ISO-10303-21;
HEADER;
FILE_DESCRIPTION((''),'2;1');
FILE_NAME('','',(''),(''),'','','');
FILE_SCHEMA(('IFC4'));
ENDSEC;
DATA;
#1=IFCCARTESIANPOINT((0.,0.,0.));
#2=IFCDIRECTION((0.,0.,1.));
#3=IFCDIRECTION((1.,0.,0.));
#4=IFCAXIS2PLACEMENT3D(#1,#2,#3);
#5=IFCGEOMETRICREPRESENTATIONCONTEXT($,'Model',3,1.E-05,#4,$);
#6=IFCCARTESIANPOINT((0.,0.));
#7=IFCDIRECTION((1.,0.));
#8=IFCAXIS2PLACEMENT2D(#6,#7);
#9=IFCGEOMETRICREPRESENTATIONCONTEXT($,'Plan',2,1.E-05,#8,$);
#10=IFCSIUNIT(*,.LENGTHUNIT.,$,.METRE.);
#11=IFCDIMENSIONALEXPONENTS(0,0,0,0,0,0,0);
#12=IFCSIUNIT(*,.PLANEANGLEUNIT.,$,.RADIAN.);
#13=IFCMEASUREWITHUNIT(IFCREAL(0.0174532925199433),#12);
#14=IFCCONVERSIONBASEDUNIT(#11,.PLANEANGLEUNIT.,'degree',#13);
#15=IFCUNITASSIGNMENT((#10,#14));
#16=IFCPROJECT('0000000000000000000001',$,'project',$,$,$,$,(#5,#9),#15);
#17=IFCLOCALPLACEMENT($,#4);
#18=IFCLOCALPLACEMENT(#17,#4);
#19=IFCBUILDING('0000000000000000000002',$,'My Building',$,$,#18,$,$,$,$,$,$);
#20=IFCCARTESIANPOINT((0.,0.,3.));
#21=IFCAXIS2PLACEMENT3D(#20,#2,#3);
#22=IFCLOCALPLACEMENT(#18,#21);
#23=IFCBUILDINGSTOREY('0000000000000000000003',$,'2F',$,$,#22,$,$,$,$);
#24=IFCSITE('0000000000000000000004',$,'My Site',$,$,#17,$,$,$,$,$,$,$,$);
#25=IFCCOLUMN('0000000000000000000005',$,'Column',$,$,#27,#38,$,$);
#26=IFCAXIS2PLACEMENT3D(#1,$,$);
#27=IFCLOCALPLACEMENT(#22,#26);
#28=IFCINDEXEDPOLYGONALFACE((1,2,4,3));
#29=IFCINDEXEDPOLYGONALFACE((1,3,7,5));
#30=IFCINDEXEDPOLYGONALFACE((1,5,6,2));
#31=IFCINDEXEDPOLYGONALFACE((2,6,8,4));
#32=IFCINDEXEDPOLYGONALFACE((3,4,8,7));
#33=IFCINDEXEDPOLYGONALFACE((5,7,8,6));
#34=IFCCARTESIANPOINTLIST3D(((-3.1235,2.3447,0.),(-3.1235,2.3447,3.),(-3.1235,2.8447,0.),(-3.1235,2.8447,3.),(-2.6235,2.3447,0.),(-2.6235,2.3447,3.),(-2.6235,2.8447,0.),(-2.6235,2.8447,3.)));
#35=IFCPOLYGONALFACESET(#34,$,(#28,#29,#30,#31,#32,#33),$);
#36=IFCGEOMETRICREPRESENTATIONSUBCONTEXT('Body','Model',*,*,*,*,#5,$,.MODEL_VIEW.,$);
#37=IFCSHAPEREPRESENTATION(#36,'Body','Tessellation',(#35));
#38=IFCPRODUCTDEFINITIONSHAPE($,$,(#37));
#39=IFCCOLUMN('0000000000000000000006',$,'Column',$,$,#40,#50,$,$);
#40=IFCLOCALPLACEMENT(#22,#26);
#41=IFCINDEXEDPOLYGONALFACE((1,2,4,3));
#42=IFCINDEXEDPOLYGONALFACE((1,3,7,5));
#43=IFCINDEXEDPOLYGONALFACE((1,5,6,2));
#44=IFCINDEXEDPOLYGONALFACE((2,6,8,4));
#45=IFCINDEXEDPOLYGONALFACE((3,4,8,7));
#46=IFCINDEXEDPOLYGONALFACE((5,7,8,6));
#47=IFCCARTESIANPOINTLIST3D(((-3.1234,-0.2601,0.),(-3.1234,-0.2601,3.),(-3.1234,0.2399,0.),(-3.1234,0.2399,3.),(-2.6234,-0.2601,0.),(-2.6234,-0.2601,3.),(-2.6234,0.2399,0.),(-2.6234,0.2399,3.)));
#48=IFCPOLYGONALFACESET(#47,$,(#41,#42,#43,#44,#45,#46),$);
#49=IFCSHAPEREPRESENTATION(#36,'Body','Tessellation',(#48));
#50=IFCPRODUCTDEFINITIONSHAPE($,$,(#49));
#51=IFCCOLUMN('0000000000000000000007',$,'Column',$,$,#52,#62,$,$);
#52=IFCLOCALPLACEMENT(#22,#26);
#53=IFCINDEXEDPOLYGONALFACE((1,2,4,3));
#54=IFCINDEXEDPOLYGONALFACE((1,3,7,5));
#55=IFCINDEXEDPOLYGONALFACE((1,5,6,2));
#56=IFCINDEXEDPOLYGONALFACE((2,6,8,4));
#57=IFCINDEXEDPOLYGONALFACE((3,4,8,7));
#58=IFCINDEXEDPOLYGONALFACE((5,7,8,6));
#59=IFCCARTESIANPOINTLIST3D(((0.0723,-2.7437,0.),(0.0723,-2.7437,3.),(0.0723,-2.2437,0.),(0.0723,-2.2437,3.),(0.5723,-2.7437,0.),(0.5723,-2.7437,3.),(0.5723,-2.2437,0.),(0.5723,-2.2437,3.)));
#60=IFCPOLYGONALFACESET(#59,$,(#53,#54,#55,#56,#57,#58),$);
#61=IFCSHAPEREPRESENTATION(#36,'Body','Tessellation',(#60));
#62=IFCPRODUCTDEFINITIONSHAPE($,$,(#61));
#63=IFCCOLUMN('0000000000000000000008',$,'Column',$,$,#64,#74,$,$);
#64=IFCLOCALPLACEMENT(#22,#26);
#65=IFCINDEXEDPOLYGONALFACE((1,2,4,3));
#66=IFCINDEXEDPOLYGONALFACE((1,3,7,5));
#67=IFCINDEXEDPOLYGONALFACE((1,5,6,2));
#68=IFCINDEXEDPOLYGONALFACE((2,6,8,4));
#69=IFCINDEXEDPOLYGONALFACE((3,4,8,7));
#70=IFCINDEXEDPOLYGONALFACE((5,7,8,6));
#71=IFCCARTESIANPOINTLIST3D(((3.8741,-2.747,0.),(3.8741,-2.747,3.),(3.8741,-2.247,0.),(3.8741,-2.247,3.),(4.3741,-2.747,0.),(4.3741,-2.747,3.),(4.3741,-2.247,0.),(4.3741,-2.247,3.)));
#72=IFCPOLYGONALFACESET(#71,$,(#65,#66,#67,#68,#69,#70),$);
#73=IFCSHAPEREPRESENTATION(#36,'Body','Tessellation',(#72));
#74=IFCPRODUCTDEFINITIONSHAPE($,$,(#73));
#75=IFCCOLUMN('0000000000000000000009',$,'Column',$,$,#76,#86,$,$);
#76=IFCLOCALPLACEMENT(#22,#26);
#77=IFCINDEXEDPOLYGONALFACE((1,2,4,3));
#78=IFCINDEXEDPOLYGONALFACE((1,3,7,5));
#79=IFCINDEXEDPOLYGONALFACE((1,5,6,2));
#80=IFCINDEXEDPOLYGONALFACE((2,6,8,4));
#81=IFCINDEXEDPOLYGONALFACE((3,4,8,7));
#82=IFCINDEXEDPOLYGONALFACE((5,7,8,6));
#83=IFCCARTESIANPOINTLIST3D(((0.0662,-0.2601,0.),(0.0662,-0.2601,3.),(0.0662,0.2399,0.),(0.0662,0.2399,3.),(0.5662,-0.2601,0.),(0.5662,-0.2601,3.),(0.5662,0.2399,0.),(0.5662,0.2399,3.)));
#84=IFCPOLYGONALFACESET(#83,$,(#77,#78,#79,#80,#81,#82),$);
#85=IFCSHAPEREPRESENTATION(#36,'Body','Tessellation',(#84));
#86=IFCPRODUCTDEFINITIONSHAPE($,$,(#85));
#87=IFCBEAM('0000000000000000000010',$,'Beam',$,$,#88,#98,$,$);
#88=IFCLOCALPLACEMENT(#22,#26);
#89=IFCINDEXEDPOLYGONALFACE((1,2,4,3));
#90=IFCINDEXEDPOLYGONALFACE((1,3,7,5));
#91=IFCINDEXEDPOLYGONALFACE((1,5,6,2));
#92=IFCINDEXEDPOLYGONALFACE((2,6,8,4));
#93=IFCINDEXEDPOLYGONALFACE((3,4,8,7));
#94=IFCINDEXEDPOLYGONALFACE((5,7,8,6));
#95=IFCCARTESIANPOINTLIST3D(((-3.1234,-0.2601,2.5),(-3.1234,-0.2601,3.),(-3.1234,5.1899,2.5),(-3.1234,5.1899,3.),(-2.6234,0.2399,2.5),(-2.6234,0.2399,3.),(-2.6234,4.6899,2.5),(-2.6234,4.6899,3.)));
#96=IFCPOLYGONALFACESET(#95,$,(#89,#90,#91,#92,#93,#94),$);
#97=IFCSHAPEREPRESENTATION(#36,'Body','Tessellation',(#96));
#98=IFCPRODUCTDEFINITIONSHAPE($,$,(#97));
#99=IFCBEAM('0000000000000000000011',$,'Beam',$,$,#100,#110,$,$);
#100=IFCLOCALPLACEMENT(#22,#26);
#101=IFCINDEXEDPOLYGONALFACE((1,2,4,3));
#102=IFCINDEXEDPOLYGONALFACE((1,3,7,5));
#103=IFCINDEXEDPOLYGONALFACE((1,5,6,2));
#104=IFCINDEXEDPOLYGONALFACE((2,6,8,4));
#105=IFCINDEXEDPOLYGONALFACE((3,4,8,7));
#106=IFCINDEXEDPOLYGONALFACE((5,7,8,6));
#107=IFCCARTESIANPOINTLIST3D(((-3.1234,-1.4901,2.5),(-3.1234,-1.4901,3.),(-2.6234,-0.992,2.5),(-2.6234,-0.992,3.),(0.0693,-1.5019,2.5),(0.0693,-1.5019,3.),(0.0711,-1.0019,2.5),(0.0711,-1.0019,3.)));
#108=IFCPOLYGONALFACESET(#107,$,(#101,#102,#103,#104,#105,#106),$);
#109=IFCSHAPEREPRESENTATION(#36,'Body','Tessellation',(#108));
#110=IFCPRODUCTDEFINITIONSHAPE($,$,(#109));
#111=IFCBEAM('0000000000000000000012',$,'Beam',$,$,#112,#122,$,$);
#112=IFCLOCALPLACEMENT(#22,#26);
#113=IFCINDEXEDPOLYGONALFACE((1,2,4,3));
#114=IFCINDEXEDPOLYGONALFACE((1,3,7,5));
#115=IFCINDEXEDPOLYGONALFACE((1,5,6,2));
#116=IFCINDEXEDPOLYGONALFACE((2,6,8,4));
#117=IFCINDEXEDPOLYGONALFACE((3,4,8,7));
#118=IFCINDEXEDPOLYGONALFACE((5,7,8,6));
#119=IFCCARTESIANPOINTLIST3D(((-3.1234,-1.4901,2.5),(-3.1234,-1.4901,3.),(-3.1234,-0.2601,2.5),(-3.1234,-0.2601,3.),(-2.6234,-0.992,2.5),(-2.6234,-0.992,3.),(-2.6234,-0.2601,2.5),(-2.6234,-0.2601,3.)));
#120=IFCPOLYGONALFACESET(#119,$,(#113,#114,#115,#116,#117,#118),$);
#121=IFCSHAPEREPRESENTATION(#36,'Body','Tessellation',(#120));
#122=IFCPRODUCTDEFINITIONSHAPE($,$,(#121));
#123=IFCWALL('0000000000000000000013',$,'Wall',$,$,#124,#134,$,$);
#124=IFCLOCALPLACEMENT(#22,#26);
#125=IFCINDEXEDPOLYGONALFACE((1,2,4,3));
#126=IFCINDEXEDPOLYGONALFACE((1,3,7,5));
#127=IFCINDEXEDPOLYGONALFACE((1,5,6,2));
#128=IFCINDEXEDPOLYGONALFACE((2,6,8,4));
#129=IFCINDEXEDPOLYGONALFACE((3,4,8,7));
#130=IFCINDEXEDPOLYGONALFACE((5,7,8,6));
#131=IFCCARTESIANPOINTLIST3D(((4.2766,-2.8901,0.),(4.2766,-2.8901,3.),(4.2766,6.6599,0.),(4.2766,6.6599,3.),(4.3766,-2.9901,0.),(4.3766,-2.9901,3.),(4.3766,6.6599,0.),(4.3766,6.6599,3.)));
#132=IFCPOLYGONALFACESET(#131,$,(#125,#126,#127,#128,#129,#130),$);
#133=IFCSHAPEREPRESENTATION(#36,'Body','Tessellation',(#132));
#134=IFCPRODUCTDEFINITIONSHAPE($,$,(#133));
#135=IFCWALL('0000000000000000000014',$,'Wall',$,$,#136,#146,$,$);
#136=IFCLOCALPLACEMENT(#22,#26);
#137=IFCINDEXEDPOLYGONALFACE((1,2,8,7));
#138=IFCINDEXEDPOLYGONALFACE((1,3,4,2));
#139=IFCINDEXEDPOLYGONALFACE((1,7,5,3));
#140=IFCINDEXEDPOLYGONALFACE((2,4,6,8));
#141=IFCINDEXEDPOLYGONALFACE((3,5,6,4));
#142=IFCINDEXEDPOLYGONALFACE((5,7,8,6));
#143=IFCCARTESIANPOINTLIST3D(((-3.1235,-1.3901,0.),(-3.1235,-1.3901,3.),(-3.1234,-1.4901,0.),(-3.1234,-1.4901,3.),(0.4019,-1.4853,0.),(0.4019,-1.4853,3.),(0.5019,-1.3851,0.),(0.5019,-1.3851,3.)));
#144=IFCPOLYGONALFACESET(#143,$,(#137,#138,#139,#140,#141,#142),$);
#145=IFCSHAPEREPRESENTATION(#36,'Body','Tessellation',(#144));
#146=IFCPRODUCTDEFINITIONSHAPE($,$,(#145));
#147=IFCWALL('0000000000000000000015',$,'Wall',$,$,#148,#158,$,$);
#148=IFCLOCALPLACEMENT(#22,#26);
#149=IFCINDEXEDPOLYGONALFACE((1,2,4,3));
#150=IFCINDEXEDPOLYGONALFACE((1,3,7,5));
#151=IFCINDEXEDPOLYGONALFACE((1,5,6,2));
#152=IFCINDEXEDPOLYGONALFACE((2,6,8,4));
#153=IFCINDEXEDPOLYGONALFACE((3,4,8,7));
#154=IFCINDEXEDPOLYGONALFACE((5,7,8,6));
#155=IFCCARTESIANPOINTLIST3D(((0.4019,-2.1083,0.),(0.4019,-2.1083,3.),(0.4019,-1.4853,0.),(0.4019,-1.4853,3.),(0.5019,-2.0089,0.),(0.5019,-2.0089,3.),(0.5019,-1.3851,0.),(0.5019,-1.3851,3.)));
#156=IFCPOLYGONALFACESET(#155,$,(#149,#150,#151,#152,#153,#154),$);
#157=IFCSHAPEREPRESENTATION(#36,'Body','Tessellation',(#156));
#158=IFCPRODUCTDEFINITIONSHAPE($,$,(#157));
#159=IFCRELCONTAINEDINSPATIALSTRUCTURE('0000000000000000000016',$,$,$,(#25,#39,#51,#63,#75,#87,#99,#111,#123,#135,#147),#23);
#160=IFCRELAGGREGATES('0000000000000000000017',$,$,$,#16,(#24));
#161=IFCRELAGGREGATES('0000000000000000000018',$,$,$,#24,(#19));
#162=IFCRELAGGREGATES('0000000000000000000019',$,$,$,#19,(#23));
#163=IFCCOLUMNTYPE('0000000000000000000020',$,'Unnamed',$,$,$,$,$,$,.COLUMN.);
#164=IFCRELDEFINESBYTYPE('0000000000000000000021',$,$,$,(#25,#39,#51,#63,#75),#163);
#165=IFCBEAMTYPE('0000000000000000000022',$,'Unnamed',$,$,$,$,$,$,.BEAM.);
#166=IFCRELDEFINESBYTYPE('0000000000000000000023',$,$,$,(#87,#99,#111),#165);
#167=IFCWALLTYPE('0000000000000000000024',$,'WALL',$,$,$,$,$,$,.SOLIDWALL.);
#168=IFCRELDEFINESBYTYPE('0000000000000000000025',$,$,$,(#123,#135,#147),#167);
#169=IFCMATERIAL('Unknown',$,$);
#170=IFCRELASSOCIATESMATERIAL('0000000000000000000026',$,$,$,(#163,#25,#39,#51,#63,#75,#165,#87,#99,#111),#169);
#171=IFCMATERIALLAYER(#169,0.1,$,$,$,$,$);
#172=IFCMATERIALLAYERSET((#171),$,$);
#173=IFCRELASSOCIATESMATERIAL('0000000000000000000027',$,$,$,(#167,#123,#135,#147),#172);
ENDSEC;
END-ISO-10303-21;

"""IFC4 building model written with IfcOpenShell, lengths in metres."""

from ifc_helpers import new_model, entity, si_unit, converted_unit, frame, origin_with_axes, origin_2d_with_axis, place, context, subcontext, project, spatial, line, indexed_curve, rectangle, outline, extrude, clip, halfspace, material, layer, layer_set, layer_usage, material_profile, profile_set, profile_usage, type_object, element, save


model = new_model("IFC4")

# Units and contexts
model_context = context("Model", 3, precision=1e-05, world=origin_with_axes())
plan_context = context("Plan", 2, precision=1e-05, world=origin_2d_with_axis())
body_context_1 = subcontext(model_context, "Body", "Model", "MODEL_VIEW")
ifc_project = project(units=[si_unit("LENGTHUNIT", "METRE"), converted_unit("PLANEANGLEUNIT", "degree", entity("IfcReal", 0.0174532925199433), si_unit("PLANEANGLEUNIT", "RADIAN"), dimensions=[0, 0, 0, 0, 0, 0, 0])], contexts=[model_context, plan_context])

# Site, building, storey
site_placement = place(None, origin_with_axes())
site = spatial("IfcSite", under=ifc_project, at=site_placement, Name="My Site")
building_placement = place(site_placement, origin_with_axes())
building = spatial("IfcBuilding", under=site, at=building_placement, Name="My Building")
storey_placement = place(building_placement, frame((0.0, 0.0, 3.0), z_axis=(0.0, 0.0, 1.0), x_axis=(1.0, 0.0, 0.0)))
storey = spatial("IfcBuildingStorey", under=building, at=storey_placement, Name="2F")

# Columns
ifc_material = material(Name="Unknown")
ifc_material_profile_1 = material_profile(ifc_material, rectangle(XDim=0.5, YDim=0.5))
ifc_profile_set_1 = profile_set([ifc_material_profile_1])
ifc_profile_usage_1 = profile_usage(ifc_profile_set_1, cardinal=1)
column_type = type_object("IfcColumnType", Name="Unnamed", PredefinedType="COLUMN", material=ifc_profile_set_1)
column_1_placement = place(storey_placement, frame((-2.6235, 2.3447, 0.0), z_axis=(0.0, 0.0, 1.0), x_axis=(1.0, 0.0, 0.0)))
element("IfcColumn", 1, at=column_1_placement, inside=storey, type_object=column_type, material=ifc_profile_usage_1, Name="Column", context=body_context_1, shape_type="SweptSolid", body=[
    extrude(rectangle(XDim=0.5, YDim=0.5), frame((-0.25, 0.25, 0.0), z_axis=(0.0, 0.0, 1.0), x_axis=(1.0, 0.0, 0.0)), (0.0, 0.0, 1.0), 3.0),
])
ifc_profile_usage_2 = profile_usage(ifc_profile_set_1, cardinal=1)
column_2_placement = place(storey_placement, frame((-2.6234, -0.2601, 0.0), z_axis=(0.0, 0.0, 1.0), x_axis=(1.0, 0.0, 0.0)))
element("IfcColumn", 2, at=column_2_placement, inside=storey, type_object=column_type, material=ifc_profile_usage_2, Name="Column", context=body_context_1, shape_type="SweptSolid", body=[
    extrude(rectangle(XDim=0.5, YDim=0.5), frame((-0.25, 0.25, 0.0), z_axis=(0.0, 0.0, 1.0), x_axis=(1.0, 0.0, 0.0)), (0.0, 0.0, 1.0), 3.0),
])
ifc_profile_usage_3 = profile_usage(ifc_profile_set_1, cardinal=1)
column_3_placement = place(storey_placement, frame((0.5723, -2.7437, 0.0), z_axis=(0.0, 0.0, 1.0), x_axis=(1.0, 0.0, 0.0)))
element("IfcColumn", 3, at=column_3_placement, inside=storey, type_object=column_type, material=ifc_profile_usage_3, Name="Column", context=body_context_1, shape_type="SweptSolid", body=[
    extrude(rectangle(XDim=0.5, YDim=0.5), frame((-0.25, 0.25, 0.0), z_axis=(0.0, 0.0, 1.0), x_axis=(1.0, 0.0, 0.0)), (0.0, 0.0, 1.0), 3.0),
])
ifc_profile_usage_4 = profile_usage(ifc_profile_set_1, cardinal=1)
column_4_placement = place(storey_placement, frame((4.3741, -2.747, 0.0), z_axis=(0.0, 0.0, 1.0), x_axis=(1.0, 0.0, 0.0)))
element("IfcColumn", 4, at=column_4_placement, inside=storey, type_object=column_type, material=ifc_profile_usage_4, Name="Column", context=body_context_1, shape_type="SweptSolid", body=[
    extrude(rectangle(XDim=0.5, YDim=0.5), frame((-0.25, 0.25, 0.0), z_axis=(0.0, 0.0, 1.0), x_axis=(1.0, 0.0, 0.0)), (0.0, 0.0, 1.0), 3.0),
])
ifc_profile_usage_5 = profile_usage(ifc_profile_set_1, cardinal=1)
column_5_placement = place(storey_placement, frame((0.5662, -0.2601, 0.0), z_axis=(0.0, 0.0, 1.0), x_axis=(1.0, 0.0, 0.0)))
element("IfcColumn", 5, at=column_5_placement, inside=storey, type_object=column_type, material=ifc_profile_usage_5, Name="Column", context=body_context_1, shape_type="SweptSolid", body=[
    extrude(rectangle(XDim=0.5, YDim=0.5), frame((-0.25, 0.25, 0.0), z_axis=(0.0, 0.0, 1.0), x_axis=(1.0, 0.0, 0.0)), (0.0, 0.0, 1.0), 3.0),
])

# Beams
ifc_material_profile_2 = material_profile(ifc_material, rectangle(XDim=0.5, YDim=0.5))
ifc_profile_set_2 = profile_set([ifc_material_profile_2])
beam_type = type_object("IfcBeamType", Name="Unnamed", PredefinedType="BEAM", material=ifc_profile_set_2)
ifc_profile_usage_6 = profile_usage(ifc_profile_set_2, cardinal=7)
beam_1_placement = place(storey_placement, frame((-3.1234, -0.2601, 3.0), z_axis=(0.0, 1.0, 0.0), x_axis=(-1.0, 0.0, 0.0)))
element("IfcBeam", 6, at=beam_1_placement, inside=storey, type_object=beam_type, material=ifc_profile_usage_6, Name="Beam", context=body_context_1, shape_type="Clipping", body=[
    clip(clip(extrude(rectangle(XDim=0.5, YDim=0.5), frame((-0.25, -0.25, 0.0), z_axis=(0.0, 0.0, 1.0), x_axis=(1.0, 0.0, 0.0)), (0.0, 0.0, 1.0), 5.45), halfspace(frame((0.0, -6.0, 5.45), z_axis=(-0.707107, 0.0, 0.707107), x_axis=(0.0, 1.0, 0.0)), False)), halfspace(frame((0.0, -6.0, 0.0), z_axis=(-0.707107, 0.0, -0.707107), x_axis=(0.0, 1.0, 0.0)), False)),
])
ifc_profile_usage_7 = profile_usage(ifc_profile_set_2, cardinal=7)
beam_2_placement = place(storey_placement, frame((0.0693, -1.5019, 3.0), z_axis=(-0.999993, 0.003696, 0.0), x_axis=(-0.003696, -0.999993, 0.0)))
element("IfcBeam", 7, at=beam_2_placement, inside=storey, type_object=beam_type, material=ifc_profile_usage_7, Name="Beam", context=body_context_1, shape_type="Clipping", body=[
    clip(extrude(rectangle(XDim=0.5, YDim=0.5), frame((-0.25, -0.25, 0.0), z_axis=(0.0, 0.0, 1.0), x_axis=(1.0, 0.0, 0.0)), (0.0, 0.0, 1.0), 3.6927), halfspace(frame((0.0, -6.0, 3.1927), z_axis=(-0.705799, 0.0, 0.708412), x_axis=(0.0, 1.0, 0.0)), False)),
])
ifc_profile_usage_8 = profile_usage(ifc_profile_set_2, cardinal=7)
beam_3_placement = place(storey_placement, frame((-3.1234, -1.9901, 3.0), z_axis=(-0.000001, 1.0, 0.0), x_axis=(-1.0, -0.000001, 0.0)))
element("IfcBeam", 8, at=beam_3_placement, inside=storey, type_object=beam_type, material=ifc_profile_usage_8, Name="Beam", context=body_context_1, shape_type="Clipping", body=[
    clip(extrude(rectangle(XDim=0.5, YDim=0.5), frame((-0.25, -0.25, 0.0), z_axis=(0.0, 0.0, 1.0), x_axis=(1.0, 0.0, 0.0)), (0.0, 0.0, 1.0), 1.73), halfspace(frame((0.0, -6.0, 0.5), z_axis=(-0.705798, 0.0, -0.708413), x_axis=(0.0, 1.0, 0.0)), False)),
])

# Walls
ifc_layer = layer(ifc_material, 0.1)
ifc_layer_set = layer_set([ifc_layer])
ifc_layer_usage_1 = layer_usage(ifc_layer_set, "AXIS2", "POSITIVE", 0.0)
wall_type = type_object("IfcWallType", Name="WALL", PredefinedType="SOLIDWALL", material=ifc_layer_set)
wall_1_placement = place(storey_placement, frame((4.3766, -2.9901, 0.0), z_axis=(0.0, 0.0, 1.0), x_axis=(0.0, 1.0, 0.0)))
element("IfcWall", 9, at=wall_1_placement, inside=storey, type_object=wall_type, material=ifc_layer_usage_1, Name="Wall", context=body_context_1, shape_type="SweptSolid", body=[
    extrude(outline(indexed_curve([(0.0, 0.0), (0.1, 0.1), (9.65, 0.1), (9.65, 0.0)], segments=[line(1, 2, 3, 4, 1)])), origin_with_axes(), (0.0, 0.0, 1.0), 3.0),
])
ifc_layer_usage_2 = layer_usage(ifc_layer_set, "AXIS2", "POSITIVE", 0.0)
wall_2_placement = place(storey_placement, frame((-3.1234, -1.4901, 0.0), z_axis=(0.0, 0.0, 1.0), x_axis=(0.999999, 0.001371, 0.0)))
element("IfcWall", 10, at=wall_2_placement, inside=storey, type_object=wall_type, material=ifc_layer_usage_2, Name="Wall", context=body_context_1, shape_type="SweptSolid", body=[
    extrude(outline(indexed_curve([(0.0, 0.0), (0.0, 0.1), (3.6254, 0.1), (3.5253, 0.0)], segments=[line(1, 2, 3, 4, 1)])), origin_with_axes(), (0.0, 0.0, 1.0), 3.0),
])
ifc_layer_usage_3 = layer_usage(ifc_layer_set, "AXIS2", "POSITIVE", 0.0)
wall_3_placement = place(storey_placement, frame((0.4019, -1.4853, 0.0), z_axis=(0.0, 0.0, 1.0), x_axis=(0.0, -1.0, 0.0)))
element("IfcWall", 11, at=wall_3_placement, inside=storey, type_object=wall_type, material=ifc_layer_usage_3, Name="Wall", context=body_context_1, shape_type="SweptSolid", body=[
    extrude(outline(indexed_curve([(0.0, 0.0), (-0.1001, 0.1), (0.5237, 0.1), (0.623, 0.0)], segments=[line(1, 2, 3, 4, 1)])), origin_with_axes(), (0.0, 0.0, 1.0), 3.0),
])

save(model, "model.ifc")
